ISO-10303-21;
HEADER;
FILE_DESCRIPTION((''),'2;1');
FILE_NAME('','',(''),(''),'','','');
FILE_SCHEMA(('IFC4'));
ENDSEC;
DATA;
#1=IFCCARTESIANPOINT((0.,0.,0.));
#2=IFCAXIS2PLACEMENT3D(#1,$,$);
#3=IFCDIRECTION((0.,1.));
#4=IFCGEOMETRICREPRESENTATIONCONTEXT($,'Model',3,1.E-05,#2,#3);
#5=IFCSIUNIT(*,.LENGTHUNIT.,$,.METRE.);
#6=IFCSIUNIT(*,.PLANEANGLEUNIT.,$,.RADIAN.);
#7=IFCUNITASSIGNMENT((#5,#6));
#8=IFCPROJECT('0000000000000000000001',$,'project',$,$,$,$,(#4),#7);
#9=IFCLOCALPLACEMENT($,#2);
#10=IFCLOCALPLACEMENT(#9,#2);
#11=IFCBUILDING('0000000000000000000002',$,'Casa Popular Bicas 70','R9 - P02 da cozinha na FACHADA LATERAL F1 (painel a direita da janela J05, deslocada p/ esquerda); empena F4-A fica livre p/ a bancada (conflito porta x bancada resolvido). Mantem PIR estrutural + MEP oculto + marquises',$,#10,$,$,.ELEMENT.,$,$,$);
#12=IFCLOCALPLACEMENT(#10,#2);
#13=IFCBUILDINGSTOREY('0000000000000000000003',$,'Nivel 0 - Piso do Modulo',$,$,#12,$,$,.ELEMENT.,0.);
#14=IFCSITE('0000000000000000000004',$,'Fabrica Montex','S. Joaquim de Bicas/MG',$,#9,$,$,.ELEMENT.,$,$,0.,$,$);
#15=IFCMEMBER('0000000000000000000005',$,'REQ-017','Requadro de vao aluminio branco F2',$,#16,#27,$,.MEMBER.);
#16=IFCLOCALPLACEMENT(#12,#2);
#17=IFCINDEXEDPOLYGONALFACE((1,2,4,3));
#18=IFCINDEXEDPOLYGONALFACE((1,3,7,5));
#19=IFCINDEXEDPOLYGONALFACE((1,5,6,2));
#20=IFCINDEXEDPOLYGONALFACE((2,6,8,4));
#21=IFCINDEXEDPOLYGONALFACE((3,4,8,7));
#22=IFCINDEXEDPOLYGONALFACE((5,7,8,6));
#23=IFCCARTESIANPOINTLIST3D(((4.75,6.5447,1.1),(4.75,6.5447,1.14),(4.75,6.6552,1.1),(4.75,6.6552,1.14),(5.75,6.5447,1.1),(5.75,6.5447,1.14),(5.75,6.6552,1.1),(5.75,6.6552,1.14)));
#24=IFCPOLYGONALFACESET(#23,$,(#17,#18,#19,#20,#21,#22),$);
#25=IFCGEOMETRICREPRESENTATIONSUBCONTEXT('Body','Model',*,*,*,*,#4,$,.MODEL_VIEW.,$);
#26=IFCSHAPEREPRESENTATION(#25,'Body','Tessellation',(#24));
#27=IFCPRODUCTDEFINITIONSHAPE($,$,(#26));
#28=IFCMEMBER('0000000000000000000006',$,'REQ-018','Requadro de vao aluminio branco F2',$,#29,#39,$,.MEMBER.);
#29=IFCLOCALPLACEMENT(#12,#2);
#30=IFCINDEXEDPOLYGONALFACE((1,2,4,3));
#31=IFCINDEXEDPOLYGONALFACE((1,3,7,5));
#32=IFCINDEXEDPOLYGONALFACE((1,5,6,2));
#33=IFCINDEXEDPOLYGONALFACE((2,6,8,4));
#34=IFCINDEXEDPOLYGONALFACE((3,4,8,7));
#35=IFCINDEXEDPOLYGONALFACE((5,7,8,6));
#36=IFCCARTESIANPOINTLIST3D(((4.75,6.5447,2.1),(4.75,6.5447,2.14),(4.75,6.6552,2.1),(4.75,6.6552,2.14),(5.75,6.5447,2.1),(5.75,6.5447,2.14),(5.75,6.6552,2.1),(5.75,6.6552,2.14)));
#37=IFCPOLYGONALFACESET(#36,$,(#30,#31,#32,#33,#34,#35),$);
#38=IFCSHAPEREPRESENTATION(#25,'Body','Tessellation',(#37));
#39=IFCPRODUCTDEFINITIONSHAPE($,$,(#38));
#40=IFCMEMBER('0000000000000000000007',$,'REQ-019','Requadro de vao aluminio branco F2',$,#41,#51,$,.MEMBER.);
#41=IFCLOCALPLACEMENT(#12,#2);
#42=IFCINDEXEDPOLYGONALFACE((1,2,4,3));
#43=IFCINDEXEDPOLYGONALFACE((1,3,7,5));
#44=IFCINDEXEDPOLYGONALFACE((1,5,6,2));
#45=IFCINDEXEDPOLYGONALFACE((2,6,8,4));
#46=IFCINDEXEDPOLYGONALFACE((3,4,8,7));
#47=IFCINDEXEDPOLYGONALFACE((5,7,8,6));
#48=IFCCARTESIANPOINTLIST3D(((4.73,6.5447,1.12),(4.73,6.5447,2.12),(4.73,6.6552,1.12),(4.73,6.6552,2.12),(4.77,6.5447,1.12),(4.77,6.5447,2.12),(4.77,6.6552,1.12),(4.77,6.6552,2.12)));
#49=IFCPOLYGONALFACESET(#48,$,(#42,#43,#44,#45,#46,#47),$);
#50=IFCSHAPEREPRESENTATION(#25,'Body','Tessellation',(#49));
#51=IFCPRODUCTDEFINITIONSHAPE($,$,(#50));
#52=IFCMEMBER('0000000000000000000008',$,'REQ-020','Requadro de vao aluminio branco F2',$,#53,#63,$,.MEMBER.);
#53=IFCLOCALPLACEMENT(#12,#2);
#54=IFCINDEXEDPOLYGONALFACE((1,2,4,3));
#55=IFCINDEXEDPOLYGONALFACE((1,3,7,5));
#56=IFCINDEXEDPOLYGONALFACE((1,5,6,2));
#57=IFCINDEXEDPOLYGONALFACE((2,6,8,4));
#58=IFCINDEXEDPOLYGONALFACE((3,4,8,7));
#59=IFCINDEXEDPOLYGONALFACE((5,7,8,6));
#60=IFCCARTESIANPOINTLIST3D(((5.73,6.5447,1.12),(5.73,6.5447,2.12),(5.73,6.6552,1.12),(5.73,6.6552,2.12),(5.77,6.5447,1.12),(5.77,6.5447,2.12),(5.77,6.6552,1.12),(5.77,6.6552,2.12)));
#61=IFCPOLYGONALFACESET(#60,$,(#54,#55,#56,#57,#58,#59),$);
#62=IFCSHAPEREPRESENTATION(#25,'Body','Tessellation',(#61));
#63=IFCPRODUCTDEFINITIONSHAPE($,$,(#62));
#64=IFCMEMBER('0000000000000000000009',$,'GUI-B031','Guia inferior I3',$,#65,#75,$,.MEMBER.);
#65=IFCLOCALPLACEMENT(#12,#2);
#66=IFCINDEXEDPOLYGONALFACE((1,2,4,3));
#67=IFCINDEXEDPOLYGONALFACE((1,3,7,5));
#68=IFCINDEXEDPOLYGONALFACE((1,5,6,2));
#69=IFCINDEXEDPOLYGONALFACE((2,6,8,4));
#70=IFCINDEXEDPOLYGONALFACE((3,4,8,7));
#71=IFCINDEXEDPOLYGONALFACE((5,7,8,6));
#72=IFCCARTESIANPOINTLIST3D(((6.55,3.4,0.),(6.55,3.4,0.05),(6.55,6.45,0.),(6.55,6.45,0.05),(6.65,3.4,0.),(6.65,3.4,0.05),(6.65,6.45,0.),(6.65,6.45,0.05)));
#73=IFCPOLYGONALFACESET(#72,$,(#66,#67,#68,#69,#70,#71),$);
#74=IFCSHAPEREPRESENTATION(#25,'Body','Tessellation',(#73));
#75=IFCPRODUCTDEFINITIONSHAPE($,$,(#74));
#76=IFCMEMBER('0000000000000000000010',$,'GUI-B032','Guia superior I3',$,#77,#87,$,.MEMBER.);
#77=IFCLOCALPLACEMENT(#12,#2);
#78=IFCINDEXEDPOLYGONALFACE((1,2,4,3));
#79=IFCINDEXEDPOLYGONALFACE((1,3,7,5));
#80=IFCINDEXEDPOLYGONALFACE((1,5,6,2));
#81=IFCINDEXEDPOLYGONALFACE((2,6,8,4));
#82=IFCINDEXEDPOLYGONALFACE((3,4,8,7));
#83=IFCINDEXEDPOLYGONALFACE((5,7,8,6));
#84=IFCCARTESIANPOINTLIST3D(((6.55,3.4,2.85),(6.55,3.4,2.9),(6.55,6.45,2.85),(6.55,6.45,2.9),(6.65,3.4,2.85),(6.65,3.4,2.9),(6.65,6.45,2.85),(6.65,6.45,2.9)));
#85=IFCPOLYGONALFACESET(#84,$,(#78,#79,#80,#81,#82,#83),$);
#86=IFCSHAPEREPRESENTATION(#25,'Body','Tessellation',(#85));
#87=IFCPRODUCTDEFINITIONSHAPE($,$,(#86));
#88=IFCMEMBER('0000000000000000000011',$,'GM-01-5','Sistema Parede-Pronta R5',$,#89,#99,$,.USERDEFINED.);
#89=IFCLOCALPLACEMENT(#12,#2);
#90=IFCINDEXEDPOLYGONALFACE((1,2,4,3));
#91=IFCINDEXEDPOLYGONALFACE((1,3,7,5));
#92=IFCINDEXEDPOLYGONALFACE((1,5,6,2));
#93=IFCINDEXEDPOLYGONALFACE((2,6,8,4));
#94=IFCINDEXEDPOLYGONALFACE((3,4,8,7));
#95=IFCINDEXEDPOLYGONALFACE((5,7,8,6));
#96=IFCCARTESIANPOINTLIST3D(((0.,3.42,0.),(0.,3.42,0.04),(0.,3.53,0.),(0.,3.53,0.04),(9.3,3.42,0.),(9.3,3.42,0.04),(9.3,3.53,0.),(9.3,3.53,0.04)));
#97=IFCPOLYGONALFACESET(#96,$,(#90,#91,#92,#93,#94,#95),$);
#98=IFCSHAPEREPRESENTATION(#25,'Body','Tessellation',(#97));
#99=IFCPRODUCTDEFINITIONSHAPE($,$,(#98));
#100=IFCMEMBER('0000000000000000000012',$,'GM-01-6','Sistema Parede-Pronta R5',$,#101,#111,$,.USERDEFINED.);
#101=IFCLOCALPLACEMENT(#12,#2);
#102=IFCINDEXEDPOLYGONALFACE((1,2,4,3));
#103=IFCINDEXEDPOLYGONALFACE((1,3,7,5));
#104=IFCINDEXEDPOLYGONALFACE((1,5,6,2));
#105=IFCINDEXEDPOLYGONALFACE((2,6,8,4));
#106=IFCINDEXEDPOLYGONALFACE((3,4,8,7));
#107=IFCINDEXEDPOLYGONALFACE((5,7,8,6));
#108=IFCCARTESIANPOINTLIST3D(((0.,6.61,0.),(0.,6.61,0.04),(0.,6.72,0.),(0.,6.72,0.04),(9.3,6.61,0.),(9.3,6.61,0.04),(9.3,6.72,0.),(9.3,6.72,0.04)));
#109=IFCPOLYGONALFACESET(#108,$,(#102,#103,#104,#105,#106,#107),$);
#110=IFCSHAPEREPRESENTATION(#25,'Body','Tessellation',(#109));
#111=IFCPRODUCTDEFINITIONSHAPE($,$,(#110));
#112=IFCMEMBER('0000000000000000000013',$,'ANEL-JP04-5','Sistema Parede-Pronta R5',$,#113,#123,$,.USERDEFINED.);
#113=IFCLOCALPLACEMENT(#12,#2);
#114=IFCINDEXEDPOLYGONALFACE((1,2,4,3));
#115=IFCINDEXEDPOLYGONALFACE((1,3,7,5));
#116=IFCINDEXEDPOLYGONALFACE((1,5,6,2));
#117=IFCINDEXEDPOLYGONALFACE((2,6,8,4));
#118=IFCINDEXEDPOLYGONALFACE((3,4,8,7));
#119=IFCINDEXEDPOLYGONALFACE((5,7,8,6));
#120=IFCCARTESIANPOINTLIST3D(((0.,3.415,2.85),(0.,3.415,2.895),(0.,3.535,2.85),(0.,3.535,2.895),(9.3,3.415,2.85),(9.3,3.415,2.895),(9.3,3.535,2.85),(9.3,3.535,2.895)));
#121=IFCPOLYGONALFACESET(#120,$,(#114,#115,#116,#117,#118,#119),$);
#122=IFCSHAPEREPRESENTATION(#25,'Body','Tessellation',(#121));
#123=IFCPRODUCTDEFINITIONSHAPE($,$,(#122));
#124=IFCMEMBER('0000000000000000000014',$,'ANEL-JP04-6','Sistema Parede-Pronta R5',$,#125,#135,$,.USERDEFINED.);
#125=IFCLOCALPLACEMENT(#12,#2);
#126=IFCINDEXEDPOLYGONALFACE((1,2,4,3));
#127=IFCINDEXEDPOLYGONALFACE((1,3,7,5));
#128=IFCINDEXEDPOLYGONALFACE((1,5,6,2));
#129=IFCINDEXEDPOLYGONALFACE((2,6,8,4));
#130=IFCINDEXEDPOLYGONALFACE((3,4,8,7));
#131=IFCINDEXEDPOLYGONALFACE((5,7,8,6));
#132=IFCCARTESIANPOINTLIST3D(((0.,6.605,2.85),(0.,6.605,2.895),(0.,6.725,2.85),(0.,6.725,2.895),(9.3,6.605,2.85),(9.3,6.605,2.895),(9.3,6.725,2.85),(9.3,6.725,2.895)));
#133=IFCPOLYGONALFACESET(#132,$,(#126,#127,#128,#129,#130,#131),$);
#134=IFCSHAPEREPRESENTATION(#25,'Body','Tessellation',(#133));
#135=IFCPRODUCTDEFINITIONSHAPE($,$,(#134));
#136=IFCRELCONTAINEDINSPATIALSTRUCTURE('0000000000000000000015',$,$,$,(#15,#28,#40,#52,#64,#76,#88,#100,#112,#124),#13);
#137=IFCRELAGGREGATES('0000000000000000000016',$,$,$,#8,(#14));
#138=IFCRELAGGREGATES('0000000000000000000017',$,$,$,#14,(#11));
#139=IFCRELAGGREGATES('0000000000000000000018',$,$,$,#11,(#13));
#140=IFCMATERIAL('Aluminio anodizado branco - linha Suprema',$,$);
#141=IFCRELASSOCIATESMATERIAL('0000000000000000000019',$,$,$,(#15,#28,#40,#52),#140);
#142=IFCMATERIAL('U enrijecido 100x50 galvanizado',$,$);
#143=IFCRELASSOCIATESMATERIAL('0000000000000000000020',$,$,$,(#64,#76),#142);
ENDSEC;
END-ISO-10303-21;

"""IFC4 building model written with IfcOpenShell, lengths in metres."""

from ifc_helpers import new_model, si_unit, direction, frame, origin, origin_2d, place, context, subcontext, project, spatial, rectangle, extrude, material, element, save


model = new_model("IFC4")

# Units and contexts
model_context = context("Model", 3, precision=1e-05, world=origin(), true_north=direction((0.0, 1.0)))
body_context = subcontext(model_context, "Body", "Model", "MODEL_VIEW")
ifc_project = project(units=[si_unit("LENGTHUNIT", "METRE"), si_unit("PLANEANGLEUNIT", "RADIAN")], contexts=[model_context])

# Site, building, storey
site_placement = place(None, origin())
site = spatial("IfcSite", under=ifc_project, at=site_placement, Name="Fabrica Montex", Description="S. Joaquim de Bicas/MG", CompositionType="ELEMENT", RefElevation=0.0)
building_placement = place(site_placement, origin())
building = spatial("IfcBuilding", under=site, at=building_placement, Name="Casa Popular Bicas 70", Description="R9 - P02 da cozinha na FACHADA LATERAL F1 (painel a direita da janela J05, deslocada p/ esquerda); empena F4-A fica livre p/ a bancada (conflito porta x bancada resolvido). Mantem PIR estrutural + MEP oculto + marquises", CompositionType="ELEMENT")
storey_placement = place(building_placement, origin())
storey = spatial("IfcBuildingStorey", under=building, at=storey_placement, Name="Nivel 0 - Piso do Modulo", CompositionType="ELEMENT", Elevation=0.0)

# Members
ifc_material_1 = material(Name="Aluminio anodizado branco - linha Suprema")
for number, where, z_axis, x_axis, name in (
    (1, (4.75, 6.6, 1.12), (1.0, 0.0, 0.0), (0.0, 0.0, 1.0), "REQ-017"),
    (2, (4.75, 6.6, 2.12), (1.0, 0.0, 0.0), (0.0, 0.0, 1.0), "REQ-018"),
    (3, (4.75, 6.6, 1.12), (0.0, 0.0, 1.0), (1.0, 0.0, 0.0), "REQ-019"),
    (4, (5.75, 6.6, 1.12), (0.0, 0.0, 1.0), (1.0, 0.0, 0.0), "REQ-020"),
):
    element("IfcMember", number, at=place(storey_placement, frame(where, z_axis=z_axis, x_axis=x_axis)), inside=storey, material=ifc_material_1, Name=name, Description="Requadro de vao aluminio branco F2", PredefinedType="MEMBER", context=body_context, shape_type="SweptSolid", body=[
        extrude(rectangle(XDim=0.04, YDim=0.1105, at=origin_2d()), origin(), (0.0, 0.0, 1.0), 1.0),
    ])
ifc_material_2 = material(Name="U enrijecido 100x50 galvanizado")
for number, where, z_axis, x_axis, name, description in (
    (5, (6.6, 3.4, 0.025), (0.0, 1.0, 0.0), (0.0, 0.0, 1.0), "GUI-B031", "Guia inferior I3"),
    (6, (6.6, 3.4, 2.875), (0.0, 1.0, 0.0), (0.0, 0.0, 1.0), "GUI-B032", "Guia superior I3"),
):
    element("IfcMember", number, at=place(storey_placement, frame(where, z_axis=z_axis, x_axis=x_axis)), inside=storey, material=ifc_material_2, Name=name, Description=description, PredefinedType="MEMBER", context=body_context, shape_type="SweptSolid", body=[
        extrude(rectangle(XDim=0.05, YDim=0.1, at=origin_2d()), origin(), (0.0, 0.0, 1.0), 3.05),
    ])
for number, where, name in (
    (7, (4.65, 3.475, 0.0), "GM-01-5"),
    (8, (4.65, 6.665, 0.0), "GM-01-6"),
):
    element("IfcMember", number, at=place(storey_placement, frame(where)), inside=storey, Name=name, Description="Sistema Parede-Pronta R5", PredefinedType="USERDEFINED", context=body_context, shape_type="SweptSolid", body=[
        extrude(rectangle(XDim=9.3, YDim=0.11, at=origin_2d()), origin(), (0.0, 0.0, 1.0), 0.04),
    ])
for number, where, name in (
    (9, (4.65, 3.475, 2.85), "ANEL-JP04-5"),
    (10, (4.65, 6.665, 2.85), "ANEL-JP04-6"),
):
    element("IfcMember", number, at=place(storey_placement, frame(where)), inside=storey, Name=name, Description="Sistema Parede-Pronta R5", PredefinedType="USERDEFINED", context=body_context, shape_type="SweptSolid", body=[
        extrude(rectangle(XDim=9.3, YDim=0.12, at=origin_2d()), origin(), (0.0, 0.0, 1.0), 0.045),
    ])

save(model, "model.ifc")
